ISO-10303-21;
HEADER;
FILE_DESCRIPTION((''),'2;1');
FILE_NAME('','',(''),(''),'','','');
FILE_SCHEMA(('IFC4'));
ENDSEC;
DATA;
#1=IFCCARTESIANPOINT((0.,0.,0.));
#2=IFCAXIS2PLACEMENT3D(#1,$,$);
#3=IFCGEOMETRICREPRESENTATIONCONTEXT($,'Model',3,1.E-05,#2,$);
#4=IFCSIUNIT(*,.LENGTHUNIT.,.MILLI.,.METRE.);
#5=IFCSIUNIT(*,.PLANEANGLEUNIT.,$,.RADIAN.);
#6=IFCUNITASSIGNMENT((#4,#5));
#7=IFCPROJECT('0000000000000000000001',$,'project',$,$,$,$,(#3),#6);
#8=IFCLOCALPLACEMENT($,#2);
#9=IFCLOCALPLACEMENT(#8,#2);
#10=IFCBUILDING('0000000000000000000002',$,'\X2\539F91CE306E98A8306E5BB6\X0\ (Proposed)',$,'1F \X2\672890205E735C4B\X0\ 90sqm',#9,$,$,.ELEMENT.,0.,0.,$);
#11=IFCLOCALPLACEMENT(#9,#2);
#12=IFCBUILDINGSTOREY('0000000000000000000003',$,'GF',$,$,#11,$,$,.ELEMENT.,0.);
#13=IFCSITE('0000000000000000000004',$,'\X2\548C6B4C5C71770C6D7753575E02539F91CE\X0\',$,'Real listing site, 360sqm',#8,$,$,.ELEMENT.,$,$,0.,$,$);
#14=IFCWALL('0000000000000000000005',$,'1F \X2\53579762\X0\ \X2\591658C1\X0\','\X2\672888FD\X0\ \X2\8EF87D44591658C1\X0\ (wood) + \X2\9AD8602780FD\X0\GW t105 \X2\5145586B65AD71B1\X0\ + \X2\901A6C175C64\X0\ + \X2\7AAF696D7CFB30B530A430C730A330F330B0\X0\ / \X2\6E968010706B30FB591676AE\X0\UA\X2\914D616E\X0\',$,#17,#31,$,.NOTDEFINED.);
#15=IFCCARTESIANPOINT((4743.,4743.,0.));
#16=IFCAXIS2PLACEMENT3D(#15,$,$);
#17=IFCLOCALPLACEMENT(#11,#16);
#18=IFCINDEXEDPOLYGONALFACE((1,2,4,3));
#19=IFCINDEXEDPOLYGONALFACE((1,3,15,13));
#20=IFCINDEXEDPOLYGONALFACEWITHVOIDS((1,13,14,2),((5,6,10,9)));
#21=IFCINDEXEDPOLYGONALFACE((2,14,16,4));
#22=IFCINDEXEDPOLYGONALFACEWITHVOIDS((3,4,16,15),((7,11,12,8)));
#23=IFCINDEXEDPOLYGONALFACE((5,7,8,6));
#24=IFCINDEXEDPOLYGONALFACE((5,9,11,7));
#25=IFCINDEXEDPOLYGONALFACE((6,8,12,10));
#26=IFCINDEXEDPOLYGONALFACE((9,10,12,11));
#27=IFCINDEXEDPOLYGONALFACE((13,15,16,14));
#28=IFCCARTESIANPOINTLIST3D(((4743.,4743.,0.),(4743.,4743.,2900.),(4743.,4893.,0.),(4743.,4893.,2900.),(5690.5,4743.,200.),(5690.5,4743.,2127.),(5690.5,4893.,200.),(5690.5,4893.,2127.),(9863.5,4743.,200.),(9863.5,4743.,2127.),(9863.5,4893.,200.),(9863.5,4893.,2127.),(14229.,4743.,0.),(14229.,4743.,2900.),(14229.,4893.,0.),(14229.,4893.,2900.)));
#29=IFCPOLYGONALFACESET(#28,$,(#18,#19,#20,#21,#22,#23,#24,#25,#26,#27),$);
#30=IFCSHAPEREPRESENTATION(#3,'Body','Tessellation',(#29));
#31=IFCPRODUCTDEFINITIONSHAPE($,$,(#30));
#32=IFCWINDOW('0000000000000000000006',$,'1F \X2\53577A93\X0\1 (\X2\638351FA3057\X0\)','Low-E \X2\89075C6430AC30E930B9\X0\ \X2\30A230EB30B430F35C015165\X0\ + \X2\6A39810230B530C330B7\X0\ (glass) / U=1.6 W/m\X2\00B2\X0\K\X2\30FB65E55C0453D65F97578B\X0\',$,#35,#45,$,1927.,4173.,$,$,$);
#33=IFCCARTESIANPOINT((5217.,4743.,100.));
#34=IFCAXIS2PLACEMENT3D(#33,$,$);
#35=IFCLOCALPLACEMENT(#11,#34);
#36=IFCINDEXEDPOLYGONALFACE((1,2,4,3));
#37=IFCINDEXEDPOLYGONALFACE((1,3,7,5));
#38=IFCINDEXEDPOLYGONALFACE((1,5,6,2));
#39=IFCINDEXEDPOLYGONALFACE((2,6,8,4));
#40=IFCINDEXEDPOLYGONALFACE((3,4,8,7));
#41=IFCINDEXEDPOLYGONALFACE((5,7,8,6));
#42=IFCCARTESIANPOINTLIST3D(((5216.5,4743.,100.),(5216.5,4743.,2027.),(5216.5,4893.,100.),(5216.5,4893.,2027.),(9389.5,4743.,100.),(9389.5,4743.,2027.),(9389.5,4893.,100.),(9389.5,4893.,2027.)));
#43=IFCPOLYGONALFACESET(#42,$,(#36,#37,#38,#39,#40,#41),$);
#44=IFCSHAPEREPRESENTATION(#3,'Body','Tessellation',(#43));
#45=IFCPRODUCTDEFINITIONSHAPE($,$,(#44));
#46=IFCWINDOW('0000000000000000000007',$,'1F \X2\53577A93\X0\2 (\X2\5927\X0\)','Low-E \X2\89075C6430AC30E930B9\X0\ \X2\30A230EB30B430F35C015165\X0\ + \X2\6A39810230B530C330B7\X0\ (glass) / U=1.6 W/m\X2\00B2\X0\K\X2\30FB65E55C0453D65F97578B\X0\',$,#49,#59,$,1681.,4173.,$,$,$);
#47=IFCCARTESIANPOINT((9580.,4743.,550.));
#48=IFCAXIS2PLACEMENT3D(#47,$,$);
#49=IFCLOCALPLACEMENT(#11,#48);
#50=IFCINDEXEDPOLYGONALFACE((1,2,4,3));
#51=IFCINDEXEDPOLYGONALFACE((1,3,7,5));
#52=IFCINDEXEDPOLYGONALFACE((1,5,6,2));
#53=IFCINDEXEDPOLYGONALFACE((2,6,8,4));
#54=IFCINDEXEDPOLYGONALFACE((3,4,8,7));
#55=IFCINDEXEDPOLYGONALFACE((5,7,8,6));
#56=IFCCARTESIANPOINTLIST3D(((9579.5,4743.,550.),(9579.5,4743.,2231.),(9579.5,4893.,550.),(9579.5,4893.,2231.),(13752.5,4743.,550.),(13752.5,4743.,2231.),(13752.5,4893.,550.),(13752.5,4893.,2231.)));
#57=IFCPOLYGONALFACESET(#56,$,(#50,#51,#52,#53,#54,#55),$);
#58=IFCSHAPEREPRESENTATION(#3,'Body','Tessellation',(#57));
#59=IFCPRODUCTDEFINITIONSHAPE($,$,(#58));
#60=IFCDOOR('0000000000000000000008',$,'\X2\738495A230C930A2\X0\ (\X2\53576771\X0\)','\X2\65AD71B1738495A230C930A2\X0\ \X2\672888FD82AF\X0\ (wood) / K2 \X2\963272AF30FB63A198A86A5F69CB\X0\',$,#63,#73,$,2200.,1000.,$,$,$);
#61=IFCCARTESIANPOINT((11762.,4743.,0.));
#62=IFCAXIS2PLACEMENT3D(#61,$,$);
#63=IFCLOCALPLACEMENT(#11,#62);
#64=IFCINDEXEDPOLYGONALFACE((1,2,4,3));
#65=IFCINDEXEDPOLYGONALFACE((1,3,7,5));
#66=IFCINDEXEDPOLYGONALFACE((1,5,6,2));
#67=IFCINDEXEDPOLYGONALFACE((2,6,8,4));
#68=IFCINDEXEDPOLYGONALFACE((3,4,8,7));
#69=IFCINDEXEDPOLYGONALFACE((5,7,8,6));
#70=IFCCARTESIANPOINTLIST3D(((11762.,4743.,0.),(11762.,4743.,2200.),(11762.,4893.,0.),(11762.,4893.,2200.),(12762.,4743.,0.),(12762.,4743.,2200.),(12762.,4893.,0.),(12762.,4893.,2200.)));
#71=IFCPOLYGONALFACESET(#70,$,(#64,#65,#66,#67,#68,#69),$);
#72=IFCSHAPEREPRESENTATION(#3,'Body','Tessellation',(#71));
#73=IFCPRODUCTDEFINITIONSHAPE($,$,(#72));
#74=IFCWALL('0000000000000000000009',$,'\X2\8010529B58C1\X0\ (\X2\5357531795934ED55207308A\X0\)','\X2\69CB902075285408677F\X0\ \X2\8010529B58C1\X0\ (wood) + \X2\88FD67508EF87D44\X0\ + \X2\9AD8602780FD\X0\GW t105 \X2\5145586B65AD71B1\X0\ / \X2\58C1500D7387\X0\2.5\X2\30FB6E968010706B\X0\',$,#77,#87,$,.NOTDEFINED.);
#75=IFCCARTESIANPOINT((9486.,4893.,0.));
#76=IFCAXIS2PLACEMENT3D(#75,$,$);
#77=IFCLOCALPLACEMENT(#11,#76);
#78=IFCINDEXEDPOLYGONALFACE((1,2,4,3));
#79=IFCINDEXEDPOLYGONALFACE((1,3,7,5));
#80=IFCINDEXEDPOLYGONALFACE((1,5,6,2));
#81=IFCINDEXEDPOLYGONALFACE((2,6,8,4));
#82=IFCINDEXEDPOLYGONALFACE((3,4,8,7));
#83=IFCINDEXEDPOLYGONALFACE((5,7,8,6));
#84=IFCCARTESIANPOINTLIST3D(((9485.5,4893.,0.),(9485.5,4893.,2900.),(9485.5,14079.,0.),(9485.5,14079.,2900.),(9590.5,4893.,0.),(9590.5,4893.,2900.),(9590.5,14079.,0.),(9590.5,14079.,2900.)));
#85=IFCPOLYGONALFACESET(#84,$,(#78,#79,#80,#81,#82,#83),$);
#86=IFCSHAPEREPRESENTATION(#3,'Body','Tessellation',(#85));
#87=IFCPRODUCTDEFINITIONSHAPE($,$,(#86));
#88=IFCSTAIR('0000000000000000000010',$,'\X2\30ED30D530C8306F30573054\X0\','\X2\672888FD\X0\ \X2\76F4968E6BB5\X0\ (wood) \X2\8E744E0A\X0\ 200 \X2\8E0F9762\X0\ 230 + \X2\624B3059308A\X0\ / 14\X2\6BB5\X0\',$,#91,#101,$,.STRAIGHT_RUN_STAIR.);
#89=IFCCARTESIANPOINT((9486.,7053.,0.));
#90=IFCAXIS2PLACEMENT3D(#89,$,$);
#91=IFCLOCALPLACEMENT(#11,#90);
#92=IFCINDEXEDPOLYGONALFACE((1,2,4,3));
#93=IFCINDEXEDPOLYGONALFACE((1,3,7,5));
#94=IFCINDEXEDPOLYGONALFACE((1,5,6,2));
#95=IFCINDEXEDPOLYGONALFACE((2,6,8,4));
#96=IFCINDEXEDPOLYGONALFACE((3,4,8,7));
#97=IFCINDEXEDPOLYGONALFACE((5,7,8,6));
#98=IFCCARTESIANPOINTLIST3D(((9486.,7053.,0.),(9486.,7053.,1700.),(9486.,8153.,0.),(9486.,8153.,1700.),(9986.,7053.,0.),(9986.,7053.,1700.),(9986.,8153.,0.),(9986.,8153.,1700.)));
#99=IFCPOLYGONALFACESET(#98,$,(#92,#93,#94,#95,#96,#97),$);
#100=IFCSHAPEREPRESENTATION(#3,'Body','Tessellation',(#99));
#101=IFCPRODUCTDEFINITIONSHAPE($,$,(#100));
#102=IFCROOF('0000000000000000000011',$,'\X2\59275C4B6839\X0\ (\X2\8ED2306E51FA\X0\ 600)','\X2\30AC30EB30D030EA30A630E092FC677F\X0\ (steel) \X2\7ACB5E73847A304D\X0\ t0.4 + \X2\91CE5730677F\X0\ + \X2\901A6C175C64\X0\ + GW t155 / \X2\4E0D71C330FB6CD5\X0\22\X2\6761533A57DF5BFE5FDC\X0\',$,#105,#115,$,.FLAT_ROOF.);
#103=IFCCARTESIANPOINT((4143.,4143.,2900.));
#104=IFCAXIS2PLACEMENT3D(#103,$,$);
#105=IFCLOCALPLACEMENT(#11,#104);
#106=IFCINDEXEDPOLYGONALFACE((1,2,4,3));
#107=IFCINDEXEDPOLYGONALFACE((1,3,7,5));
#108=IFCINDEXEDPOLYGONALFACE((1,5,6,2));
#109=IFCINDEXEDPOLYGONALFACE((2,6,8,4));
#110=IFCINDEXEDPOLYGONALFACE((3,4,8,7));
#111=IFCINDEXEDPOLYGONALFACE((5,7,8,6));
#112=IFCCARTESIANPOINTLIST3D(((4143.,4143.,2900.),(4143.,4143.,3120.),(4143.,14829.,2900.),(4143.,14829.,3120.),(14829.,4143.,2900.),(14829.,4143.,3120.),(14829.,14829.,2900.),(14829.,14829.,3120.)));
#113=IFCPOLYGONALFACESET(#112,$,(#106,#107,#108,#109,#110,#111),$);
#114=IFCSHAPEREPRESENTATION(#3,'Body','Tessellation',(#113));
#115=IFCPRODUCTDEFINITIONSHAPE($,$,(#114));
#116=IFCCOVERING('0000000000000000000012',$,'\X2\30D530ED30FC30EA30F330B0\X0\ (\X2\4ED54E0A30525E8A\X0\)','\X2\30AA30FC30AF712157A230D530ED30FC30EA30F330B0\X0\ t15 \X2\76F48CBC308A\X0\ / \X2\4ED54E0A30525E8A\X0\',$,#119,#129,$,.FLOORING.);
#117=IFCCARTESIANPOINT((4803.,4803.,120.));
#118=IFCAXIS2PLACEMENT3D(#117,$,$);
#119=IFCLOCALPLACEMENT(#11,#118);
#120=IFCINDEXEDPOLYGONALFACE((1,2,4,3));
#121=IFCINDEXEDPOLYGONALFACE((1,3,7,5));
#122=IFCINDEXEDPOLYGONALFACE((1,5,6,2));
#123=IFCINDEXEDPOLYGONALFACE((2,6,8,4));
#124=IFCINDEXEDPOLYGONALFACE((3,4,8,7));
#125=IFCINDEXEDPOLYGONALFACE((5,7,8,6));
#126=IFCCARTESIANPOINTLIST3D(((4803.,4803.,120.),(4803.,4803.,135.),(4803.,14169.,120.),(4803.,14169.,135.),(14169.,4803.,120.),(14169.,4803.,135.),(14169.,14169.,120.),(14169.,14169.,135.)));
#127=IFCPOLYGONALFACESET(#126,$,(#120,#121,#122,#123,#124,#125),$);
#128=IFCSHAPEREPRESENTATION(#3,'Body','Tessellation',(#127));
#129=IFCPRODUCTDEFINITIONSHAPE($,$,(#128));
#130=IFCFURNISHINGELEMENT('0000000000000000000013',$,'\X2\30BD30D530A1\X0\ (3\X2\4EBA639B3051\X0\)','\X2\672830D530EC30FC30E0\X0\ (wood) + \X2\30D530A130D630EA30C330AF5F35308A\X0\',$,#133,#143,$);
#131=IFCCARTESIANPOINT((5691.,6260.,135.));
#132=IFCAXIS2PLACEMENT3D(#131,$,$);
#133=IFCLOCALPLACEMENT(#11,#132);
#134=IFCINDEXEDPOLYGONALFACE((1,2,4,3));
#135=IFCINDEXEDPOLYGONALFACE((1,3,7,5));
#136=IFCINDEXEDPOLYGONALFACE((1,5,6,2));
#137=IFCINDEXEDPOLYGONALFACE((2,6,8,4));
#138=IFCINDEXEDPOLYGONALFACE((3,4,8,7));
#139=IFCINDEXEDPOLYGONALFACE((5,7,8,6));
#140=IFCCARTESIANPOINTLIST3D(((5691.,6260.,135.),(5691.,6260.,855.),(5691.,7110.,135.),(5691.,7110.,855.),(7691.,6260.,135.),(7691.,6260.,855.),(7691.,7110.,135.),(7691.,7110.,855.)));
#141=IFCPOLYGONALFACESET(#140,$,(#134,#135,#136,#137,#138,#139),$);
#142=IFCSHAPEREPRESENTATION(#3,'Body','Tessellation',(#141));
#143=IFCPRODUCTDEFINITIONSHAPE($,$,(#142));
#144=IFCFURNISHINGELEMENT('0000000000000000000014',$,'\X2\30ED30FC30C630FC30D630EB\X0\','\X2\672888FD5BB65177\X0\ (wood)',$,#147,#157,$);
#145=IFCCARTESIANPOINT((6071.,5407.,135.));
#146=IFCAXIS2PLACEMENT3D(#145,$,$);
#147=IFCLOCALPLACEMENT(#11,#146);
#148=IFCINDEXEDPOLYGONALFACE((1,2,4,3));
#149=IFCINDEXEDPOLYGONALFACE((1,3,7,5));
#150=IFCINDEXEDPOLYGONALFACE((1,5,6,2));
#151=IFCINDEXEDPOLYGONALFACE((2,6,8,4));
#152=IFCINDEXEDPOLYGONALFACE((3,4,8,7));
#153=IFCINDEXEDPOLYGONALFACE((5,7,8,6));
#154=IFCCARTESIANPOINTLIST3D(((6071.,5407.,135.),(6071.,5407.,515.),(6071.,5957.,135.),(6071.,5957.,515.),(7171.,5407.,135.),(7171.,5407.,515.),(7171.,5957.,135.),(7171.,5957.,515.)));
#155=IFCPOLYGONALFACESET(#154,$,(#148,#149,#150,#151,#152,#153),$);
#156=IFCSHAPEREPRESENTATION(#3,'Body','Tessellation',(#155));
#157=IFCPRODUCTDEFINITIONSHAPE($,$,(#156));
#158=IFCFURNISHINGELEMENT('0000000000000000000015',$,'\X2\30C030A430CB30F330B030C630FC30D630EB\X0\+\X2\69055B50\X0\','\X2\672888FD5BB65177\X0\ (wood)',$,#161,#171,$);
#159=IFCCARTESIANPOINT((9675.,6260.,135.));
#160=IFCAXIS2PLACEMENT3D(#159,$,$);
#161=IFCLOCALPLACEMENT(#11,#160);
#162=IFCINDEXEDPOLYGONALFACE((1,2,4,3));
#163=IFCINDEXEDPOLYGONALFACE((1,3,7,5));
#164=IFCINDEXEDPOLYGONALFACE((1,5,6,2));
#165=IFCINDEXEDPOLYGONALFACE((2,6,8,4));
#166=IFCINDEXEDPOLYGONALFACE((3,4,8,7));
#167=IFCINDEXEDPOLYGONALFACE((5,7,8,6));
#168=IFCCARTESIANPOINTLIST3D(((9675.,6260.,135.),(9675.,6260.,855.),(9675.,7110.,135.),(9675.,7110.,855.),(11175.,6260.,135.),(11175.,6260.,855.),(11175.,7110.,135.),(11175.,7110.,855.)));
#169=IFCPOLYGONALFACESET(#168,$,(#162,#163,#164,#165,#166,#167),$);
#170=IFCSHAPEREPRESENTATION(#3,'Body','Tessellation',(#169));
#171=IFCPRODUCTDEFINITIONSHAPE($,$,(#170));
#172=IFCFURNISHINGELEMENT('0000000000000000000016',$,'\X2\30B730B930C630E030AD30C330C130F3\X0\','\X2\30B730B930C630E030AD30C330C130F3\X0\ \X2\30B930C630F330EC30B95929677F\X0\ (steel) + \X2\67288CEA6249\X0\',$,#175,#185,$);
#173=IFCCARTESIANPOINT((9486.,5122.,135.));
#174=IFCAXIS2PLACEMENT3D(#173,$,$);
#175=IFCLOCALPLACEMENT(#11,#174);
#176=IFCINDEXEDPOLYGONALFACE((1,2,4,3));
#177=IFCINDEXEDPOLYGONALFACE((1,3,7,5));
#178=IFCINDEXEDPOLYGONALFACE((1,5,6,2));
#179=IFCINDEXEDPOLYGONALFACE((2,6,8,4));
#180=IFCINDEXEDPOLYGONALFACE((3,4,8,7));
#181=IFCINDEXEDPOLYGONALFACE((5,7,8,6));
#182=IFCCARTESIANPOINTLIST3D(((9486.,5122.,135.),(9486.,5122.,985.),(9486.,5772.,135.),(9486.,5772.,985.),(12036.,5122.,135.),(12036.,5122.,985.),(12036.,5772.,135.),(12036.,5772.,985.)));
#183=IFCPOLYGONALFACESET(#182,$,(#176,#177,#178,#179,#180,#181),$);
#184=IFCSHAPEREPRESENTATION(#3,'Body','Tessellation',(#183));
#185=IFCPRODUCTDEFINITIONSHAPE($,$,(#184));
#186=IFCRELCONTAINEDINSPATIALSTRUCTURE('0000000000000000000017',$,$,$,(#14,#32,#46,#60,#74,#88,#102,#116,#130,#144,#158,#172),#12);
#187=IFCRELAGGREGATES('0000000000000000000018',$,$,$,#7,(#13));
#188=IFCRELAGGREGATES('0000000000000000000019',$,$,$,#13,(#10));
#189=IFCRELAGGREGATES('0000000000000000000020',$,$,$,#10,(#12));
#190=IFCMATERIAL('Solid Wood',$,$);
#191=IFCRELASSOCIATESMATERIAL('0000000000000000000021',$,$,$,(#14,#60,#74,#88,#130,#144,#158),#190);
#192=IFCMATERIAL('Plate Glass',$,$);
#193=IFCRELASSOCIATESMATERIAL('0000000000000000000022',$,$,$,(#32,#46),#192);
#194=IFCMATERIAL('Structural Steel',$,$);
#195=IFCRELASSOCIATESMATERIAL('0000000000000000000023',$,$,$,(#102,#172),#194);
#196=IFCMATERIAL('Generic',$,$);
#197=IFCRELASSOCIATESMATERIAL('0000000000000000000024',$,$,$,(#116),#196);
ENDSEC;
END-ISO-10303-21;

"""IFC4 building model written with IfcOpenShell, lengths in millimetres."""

from ifc_helpers import new_model, si_unit, frame, frame_2d, origin, place, context, project, spatial, rectangle, extrude, material, element, fill, save


model = new_model("IFC4")

# Units and contexts
model_context = context("Model", 3, precision=1e-05, world=origin())
ifc_project = project(units=[si_unit("LENGTHUNIT", "METRE", prefix="MILLI"), si_unit("PLANEANGLEUNIT", "RADIAN")], contexts=[model_context])

# Site, building, storey
site_placement = place(None, origin())
site = spatial("IfcSite", under=ifc_project, at=site_placement, Name="和歌山県海南市原野", ObjectType="Real listing site, 360sqm", CompositionType="ELEMENT", RefElevation=0.0)
building_placement = place(site_placement, origin())
building = spatial("IfcBuilding", under=site, at=building_placement, Name="原野の風の家 (Proposed)", ObjectType="1F 木造平屋 90sqm", CompositionType="ELEMENT", ElevationOfRefHeight=0.0, ElevationOfTerrain=0.0)
storey_placement = place(building_placement, origin())
storey = spatial("IfcBuildingStorey", under=building, at=storey_placement, Name="GF", CompositionType="ELEMENT", Elevation=0.0)

# Shared definitions
ifc_material_1 = material(Name="Solid Wood")

# Wall, openings, windows, door
wall_1_placement = place(storey_placement, frame((4743.0, 4743.0, 0.0)))
wall_1 = element("IfcWall", 1, at=wall_1_placement, inside=storey, material=ifc_material_1, Name="1F 南面 外壁", Description="木製 軸組外壁 (wood) + 高性能GW t105 充填断熱 + 通気層 + 窯業系サイディング / 準耐火・外皮UA配慮", PredefinedType="NOTDEFINED", context=model_context, shape_type="SweptSolid", body=[
    extrude(rectangle(XDim=9486.0, YDim=150.0, at=frame_2d((4743.0, 75.0))), frame((4743.0, 4743.0, 0.0)), (0.0, 0.0, 1.0), 2900.0),
])
opening_1_placement = place(storey_placement, frame((5217.0, 4743.0, 100.0)))
opening_1 = element("IfcOpeningElement", 2, at=opening_1_placement, cuts=wall_1, PredefinedType="NOTDEFINED", context=model_context, shape_type="SweptSolid", body=[
    extrude(rectangle(XDim=4173.0, YDim=150.0, at=frame_2d((2086.0, 75.0))), frame((5217.0, 4743.0, 100.0)), (0.0, 0.0, 1.0), 1927.0),
])
opening_2_placement = place(storey_placement, frame((9580.0, 4743.0, 550.0)))
opening_2 = element("IfcOpeningElement", 3, at=opening_2_placement, cuts=wall_1, PredefinedType="NOTDEFINED", context=model_context, shape_type="SweptSolid", body=[
    extrude(rectangle(XDim=4173.0, YDim=150.0, at=frame_2d((2086.0, 75.0))), frame((9580.0, 4743.0, 550.0)), (0.0, 0.0, 1.0), 1681.0),
])
opening_3_placement = place(storey_placement, frame((11762.0, 4743.0, 0.0)))
opening_3 = element("IfcOpeningElement", 4, at=opening_3_placement, cuts=wall_1, PredefinedType="NOTDEFINED", context=model_context, shape_type="SweptSolid", body=[
    extrude(rectangle(XDim=1000.0, YDim=150.0, at=frame_2d((500.0, 75.0))), frame((11762.0, 4743.0, 0.0)), (0.0, 0.0, 1.0), 2200.0),
])
ifc_material_2 = material(Name="Plate Glass")
window_1_placement = place(storey_placement, frame((5217.0, 4743.0, 100.0)))
window_1 = element("IfcWindow", 5, at=window_1_placement, inside=storey, material=ifc_material_2, Name="1F 南窓1 (掃出し)", Description="Low-E 複層ガラス アルゴン封入 + 樹脂サッシ (glass) / U=1.6 W/m²K・日射取得型", OverallHeight=1927.0, OverallWidth=4173.0, context=model_context, shape_type="SweptSolid", body=[
    extrude(rectangle(XDim=4173.0, YDim=150.0, at=frame_2d((2086.0, 75.0))), frame((5217.0, 4743.0, 100.0)), (0.0, 0.0, 1.0), 1927.0),
])
fill(opening_1, window_1)
window_2_placement = place(storey_placement, frame((9580.0, 4743.0, 550.0)))
window_2 = element("IfcWindow", 6, at=window_2_placement, inside=storey, material=ifc_material_2, Name="1F 南窓2 (大)", Description="Low-E 複層ガラス アルゴン封入 + 樹脂サッシ (glass) / U=1.6 W/m²K・日射取得型", OverallHeight=1681.0, OverallWidth=4173.0, context=model_context, shape_type="SweptSolid", body=[
    extrude(rectangle(XDim=4173.0, YDim=150.0, at=frame_2d((2086.0, 75.0))), frame((9580.0, 4743.0, 550.0)), (0.0, 0.0, 1.0), 1681.0),
])
fill(opening_2, window_2)
door_placement = place(storey_placement, frame((11762.0, 4743.0, 0.0)))
door = element("IfcDoor", 7, at=door_placement, inside=storey, material=ifc_material_1, Name="玄関ドア (南東)", Description="断熱玄関ドア 木製芯 (wood) / K2 防犯・採風機構", OverallHeight=2200.0, OverallWidth=1000.0, context=model_context, shape_type="SweptSolid", body=[
    extrude(rectangle(XDim=1000.0, YDim=150.0, at=frame_2d((500.0, 75.0))), frame((11762.0, 4743.0, 0.0)), (0.0, 0.0, 1.0), 2200.0),
])
fill(opening_3, door)

# Wall
wall_2_placement = place(storey_placement, frame((9486.0, 4893.0, 0.0)))
element("IfcWall", 8, at=wall_2_placement, inside=storey, material=ifc_material_1, Name="耐力壁 (南北間仕切り)", Description="構造用合板 耐力壁 (wood) + 製材軸組 + 高性能GW t105 充填断熱 / 壁倍率2.5・準耐火", PredefinedType="NOTDEFINED", context=model_context, shape_type="SweptSolid", body=[
    extrude(rectangle(XDim=105.0, YDim=9186.0, at=frame_2d((52.0, 4593.0))), frame((9486.0, 4893.0, 0.0)), (0.0, 0.0, 1.0), 2900.0),
])

# Stair
stair_placement = place(storey_placement, frame((9486.0, 7053.0, 0.0)))
element("IfcStair", 9, at=stair_placement, inside=storey, material=ifc_material_1, Name="ロフトはしご", Description="木製 直階段 (wood) 蹴上 200 踏面 230 + 手すり / 14段", PredefinedType="STRAIGHT_RUN_STAIR", context=model_context, shape_type="SweptSolid", body=[
    extrude(rectangle(XDim=500.0, YDim=1100.0, at=frame_2d((250.0, 550.0))), frame((9486.0, 7053.0, 0.0)), (0.0, 0.0, 1.0), 1700.0),
])

# Roof
ifc_material_3 = material(Name="Structural Steel")
roof_placement = place(storey_placement, frame((4143.0, 4143.0, 2900.0)))
element("IfcRoof", 10, at=roof_placement, inside=storey, material=ifc_material_3, Name="大屋根 (軒の出 600)", Description="ガルバリウム鋼板 (steel) 立平葺き t0.4 + 野地板 + 通気層 + GW t155 / 不燃・法22条区域対応", PredefinedType="FLAT_ROOF", context=model_context, shape_type="SweptSolid", body=[
    extrude(rectangle(XDim=10686.0, YDim=10686.0, at=frame_2d((5343.0, 5343.0))), frame((4143.0, 4143.0, 2900.0)), (0.0, 0.0, 1.0), 220.0),
])

# Covering
ifc_material_4 = material(Name="Generic")
covering_placement = place(storey_placement, frame((4803.0, 4803.0, 120.0)))
element("IfcCovering", 11, at=covering_placement, inside=storey, material=ifc_material_4, Name="フローリング (仕上げ床)", Description="オーク無垢フローリング t15 直貼り / 仕上げ床", PredefinedType="FLOORING", context=model_context, shape_type="SweptSolid", body=[
    extrude(rectangle(XDim=9366.0, YDim=9366.0, at=frame_2d((4683.0, 4683.0))), frame((4803.0, 4803.0, 120.0)), (0.0, 0.0, 1.0), 15.0),
])

# Furnishing elements
furnishing_1_placement = place(storey_placement, frame((5691.0, 6260.0, 135.0)))
element("IfcFurnishingElement", 12, at=furnishing_1_placement, inside=storey, material=ifc_material_1, Name="ソファ (3人掛け)", Description="木フレーム (wood) + ファブリック張り", context=model_context, shape_type="SweptSolid", body=[
    extrude(rectangle(XDim=2000.0, YDim=850.0, at=frame_2d((1000.0, 425.0))), frame((5691.0, 6260.0, 135.0)), (0.0, 0.0, 1.0), 720.0),
])
furnishing_2_placement = place(storey_placement, frame((6071.0, 5407.0, 135.0)))
element("IfcFurnishingElement", 13, at=furnishing_2_placement, inside=storey, material=ifc_material_1, Name="ローテーブル", Description="木製家具 (wood)", context=model_context, shape_type="SweptSolid", body=[
    extrude(rectangle(XDim=1100.0, YDim=550.0, at=frame_2d((550.0, 275.0))), frame((6071.0, 5407.0, 135.0)), (0.0, 0.0, 1.0), 380.0),
])
furnishing_3_placement = place(storey_placement, frame((9675.0, 6260.0, 135.0)))
element("IfcFurnishingElement", 14, at=furnishing_3_placement, inside=storey, material=ifc_material_1, Name="ダイニングテーブル+椅子", Description="木製家具 (wood)", context=model_context, shape_type="SweptSolid", body=[
    extrude(rectangle(XDim=1500.0, YDim=850.0, at=frame_2d((750.0, 425.0))), frame((9675.0, 6260.0, 135.0)), (0.0, 0.0, 1.0), 720.0),
])
furnishing_4_placement = place(storey_placement, frame((9486.0, 5122.0, 135.0)))
element("IfcFurnishingElement", 15, at=furnishing_4_placement, inside=storey, material=ifc_material_3, Name="システムキッチン", Description="システムキッチン ステンレス天板 (steel) + 木質扉", context=model_context, shape_type="SweptSolid", body=[
    extrude(rectangle(XDim=2550.0, YDim=650.0, at=frame_2d((1275.0, 325.0))), frame((9486.0, 5122.0, 135.0)), (0.0, 0.0, 1.0), 850.0),
])

save(model, "model.ifc")
